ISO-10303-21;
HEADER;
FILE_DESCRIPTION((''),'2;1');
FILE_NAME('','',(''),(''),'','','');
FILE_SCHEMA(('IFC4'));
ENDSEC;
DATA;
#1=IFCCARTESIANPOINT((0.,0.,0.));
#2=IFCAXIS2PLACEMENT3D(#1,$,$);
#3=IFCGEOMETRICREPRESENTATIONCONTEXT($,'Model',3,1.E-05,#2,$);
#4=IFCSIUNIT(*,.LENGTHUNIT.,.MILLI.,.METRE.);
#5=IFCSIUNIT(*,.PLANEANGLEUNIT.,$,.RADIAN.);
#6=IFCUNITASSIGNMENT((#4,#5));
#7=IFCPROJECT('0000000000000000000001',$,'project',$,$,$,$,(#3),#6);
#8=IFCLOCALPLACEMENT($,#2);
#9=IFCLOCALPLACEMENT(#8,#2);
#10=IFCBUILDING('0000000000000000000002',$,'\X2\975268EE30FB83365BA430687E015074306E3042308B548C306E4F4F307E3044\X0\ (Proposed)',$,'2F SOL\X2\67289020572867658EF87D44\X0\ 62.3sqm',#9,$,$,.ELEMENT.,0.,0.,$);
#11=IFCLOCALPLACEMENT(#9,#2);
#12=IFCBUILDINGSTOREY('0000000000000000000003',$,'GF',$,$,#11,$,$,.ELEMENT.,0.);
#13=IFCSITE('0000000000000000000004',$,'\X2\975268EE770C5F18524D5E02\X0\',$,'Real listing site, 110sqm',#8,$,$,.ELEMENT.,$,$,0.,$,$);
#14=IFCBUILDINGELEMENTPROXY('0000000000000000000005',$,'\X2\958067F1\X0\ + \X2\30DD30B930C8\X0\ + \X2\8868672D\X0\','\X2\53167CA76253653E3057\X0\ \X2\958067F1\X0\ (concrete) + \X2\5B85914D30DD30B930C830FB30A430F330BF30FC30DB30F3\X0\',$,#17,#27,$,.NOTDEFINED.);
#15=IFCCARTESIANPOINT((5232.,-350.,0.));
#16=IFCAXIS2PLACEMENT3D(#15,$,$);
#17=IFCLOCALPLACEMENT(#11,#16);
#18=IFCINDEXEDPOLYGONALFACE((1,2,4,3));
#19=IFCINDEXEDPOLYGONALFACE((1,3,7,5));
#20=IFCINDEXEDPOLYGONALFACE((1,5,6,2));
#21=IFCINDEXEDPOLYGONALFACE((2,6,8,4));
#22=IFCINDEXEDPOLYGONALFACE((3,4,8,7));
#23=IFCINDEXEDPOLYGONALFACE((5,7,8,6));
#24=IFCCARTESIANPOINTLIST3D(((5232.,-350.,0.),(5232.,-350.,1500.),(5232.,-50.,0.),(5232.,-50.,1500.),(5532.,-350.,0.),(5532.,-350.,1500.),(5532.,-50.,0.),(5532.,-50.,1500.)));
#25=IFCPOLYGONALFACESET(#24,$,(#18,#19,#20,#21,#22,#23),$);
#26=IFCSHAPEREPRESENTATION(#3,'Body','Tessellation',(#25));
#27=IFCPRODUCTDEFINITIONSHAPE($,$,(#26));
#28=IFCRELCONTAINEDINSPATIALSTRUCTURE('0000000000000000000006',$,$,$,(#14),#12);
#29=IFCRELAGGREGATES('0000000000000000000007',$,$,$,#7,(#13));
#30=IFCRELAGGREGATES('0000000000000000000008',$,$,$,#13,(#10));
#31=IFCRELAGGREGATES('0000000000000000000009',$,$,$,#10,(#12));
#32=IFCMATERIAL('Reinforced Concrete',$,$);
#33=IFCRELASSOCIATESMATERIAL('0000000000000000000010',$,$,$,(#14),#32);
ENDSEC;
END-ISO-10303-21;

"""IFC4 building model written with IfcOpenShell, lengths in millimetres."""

from ifc_helpers import new_model, si_unit, frame, frame_2d, origin, place, context, project, spatial, rectangle, extrude, material, element, save


model = new_model("IFC4")

# Units and contexts
model_context = context("Model", 3, precision=1e-05, world=origin())
ifc_project = project(units=[si_unit("LENGTHUNIT", "METRE", prefix="MILLI"), si_unit("PLANEANGLEUNIT", "RADIAN")], contexts=[model_context])

# Site, building, storey
site_placement = place(None, origin())
site = spatial("IfcSite", under=ifc_project, at=site_placement, Name="青森県弘前市", ObjectType="Real listing site, 110sqm", CompositionType="ELEMENT", RefElevation=0.0)
building_placement = place(site_placement, origin())
building = spatial("IfcBuilding", under=site, at=building_placement, Name="青森・茶室と縁側のある和の住まい (Proposed)", ObjectType="2F SOL木造在来軸組 62.3sqm", CompositionType="ELEMENT", ElevationOfRefHeight=0.0, ElevationOfTerrain=0.0)
storey_placement = place(building_placement, origin())
storey = spatial("IfcBuildingStorey", under=building, at=storey_placement, Name="GF", CompositionType="ELEMENT", Elevation=0.0)

# Shared definitions
ifc_material_1 = material(Name="Reinforced Concrete")

# Building element proxy
proxy_placement = place(storey_placement, frame((5232.0, -350.0, 0.0)))
element("IfcBuildingElementProxy", 1, at=proxy_placement, inside=storey, material=ifc_material_1, Name="門柱 + ポスト + 表札", Description="化粧打放し 門柱 (concrete) + 宅配ポスト・インターホン", PredefinedType="NOTDEFINED", context=model_context, shape_type="SweptSolid", body=[
    extrude(rectangle(XDim=300.0, YDim=300.0, at=frame_2d((150.0, 150.0))), frame((5232.0, -350.0, 0.0)), (0.0, 0.0, 1.0), 1500.0),
])

save(model, "model.ifc")
